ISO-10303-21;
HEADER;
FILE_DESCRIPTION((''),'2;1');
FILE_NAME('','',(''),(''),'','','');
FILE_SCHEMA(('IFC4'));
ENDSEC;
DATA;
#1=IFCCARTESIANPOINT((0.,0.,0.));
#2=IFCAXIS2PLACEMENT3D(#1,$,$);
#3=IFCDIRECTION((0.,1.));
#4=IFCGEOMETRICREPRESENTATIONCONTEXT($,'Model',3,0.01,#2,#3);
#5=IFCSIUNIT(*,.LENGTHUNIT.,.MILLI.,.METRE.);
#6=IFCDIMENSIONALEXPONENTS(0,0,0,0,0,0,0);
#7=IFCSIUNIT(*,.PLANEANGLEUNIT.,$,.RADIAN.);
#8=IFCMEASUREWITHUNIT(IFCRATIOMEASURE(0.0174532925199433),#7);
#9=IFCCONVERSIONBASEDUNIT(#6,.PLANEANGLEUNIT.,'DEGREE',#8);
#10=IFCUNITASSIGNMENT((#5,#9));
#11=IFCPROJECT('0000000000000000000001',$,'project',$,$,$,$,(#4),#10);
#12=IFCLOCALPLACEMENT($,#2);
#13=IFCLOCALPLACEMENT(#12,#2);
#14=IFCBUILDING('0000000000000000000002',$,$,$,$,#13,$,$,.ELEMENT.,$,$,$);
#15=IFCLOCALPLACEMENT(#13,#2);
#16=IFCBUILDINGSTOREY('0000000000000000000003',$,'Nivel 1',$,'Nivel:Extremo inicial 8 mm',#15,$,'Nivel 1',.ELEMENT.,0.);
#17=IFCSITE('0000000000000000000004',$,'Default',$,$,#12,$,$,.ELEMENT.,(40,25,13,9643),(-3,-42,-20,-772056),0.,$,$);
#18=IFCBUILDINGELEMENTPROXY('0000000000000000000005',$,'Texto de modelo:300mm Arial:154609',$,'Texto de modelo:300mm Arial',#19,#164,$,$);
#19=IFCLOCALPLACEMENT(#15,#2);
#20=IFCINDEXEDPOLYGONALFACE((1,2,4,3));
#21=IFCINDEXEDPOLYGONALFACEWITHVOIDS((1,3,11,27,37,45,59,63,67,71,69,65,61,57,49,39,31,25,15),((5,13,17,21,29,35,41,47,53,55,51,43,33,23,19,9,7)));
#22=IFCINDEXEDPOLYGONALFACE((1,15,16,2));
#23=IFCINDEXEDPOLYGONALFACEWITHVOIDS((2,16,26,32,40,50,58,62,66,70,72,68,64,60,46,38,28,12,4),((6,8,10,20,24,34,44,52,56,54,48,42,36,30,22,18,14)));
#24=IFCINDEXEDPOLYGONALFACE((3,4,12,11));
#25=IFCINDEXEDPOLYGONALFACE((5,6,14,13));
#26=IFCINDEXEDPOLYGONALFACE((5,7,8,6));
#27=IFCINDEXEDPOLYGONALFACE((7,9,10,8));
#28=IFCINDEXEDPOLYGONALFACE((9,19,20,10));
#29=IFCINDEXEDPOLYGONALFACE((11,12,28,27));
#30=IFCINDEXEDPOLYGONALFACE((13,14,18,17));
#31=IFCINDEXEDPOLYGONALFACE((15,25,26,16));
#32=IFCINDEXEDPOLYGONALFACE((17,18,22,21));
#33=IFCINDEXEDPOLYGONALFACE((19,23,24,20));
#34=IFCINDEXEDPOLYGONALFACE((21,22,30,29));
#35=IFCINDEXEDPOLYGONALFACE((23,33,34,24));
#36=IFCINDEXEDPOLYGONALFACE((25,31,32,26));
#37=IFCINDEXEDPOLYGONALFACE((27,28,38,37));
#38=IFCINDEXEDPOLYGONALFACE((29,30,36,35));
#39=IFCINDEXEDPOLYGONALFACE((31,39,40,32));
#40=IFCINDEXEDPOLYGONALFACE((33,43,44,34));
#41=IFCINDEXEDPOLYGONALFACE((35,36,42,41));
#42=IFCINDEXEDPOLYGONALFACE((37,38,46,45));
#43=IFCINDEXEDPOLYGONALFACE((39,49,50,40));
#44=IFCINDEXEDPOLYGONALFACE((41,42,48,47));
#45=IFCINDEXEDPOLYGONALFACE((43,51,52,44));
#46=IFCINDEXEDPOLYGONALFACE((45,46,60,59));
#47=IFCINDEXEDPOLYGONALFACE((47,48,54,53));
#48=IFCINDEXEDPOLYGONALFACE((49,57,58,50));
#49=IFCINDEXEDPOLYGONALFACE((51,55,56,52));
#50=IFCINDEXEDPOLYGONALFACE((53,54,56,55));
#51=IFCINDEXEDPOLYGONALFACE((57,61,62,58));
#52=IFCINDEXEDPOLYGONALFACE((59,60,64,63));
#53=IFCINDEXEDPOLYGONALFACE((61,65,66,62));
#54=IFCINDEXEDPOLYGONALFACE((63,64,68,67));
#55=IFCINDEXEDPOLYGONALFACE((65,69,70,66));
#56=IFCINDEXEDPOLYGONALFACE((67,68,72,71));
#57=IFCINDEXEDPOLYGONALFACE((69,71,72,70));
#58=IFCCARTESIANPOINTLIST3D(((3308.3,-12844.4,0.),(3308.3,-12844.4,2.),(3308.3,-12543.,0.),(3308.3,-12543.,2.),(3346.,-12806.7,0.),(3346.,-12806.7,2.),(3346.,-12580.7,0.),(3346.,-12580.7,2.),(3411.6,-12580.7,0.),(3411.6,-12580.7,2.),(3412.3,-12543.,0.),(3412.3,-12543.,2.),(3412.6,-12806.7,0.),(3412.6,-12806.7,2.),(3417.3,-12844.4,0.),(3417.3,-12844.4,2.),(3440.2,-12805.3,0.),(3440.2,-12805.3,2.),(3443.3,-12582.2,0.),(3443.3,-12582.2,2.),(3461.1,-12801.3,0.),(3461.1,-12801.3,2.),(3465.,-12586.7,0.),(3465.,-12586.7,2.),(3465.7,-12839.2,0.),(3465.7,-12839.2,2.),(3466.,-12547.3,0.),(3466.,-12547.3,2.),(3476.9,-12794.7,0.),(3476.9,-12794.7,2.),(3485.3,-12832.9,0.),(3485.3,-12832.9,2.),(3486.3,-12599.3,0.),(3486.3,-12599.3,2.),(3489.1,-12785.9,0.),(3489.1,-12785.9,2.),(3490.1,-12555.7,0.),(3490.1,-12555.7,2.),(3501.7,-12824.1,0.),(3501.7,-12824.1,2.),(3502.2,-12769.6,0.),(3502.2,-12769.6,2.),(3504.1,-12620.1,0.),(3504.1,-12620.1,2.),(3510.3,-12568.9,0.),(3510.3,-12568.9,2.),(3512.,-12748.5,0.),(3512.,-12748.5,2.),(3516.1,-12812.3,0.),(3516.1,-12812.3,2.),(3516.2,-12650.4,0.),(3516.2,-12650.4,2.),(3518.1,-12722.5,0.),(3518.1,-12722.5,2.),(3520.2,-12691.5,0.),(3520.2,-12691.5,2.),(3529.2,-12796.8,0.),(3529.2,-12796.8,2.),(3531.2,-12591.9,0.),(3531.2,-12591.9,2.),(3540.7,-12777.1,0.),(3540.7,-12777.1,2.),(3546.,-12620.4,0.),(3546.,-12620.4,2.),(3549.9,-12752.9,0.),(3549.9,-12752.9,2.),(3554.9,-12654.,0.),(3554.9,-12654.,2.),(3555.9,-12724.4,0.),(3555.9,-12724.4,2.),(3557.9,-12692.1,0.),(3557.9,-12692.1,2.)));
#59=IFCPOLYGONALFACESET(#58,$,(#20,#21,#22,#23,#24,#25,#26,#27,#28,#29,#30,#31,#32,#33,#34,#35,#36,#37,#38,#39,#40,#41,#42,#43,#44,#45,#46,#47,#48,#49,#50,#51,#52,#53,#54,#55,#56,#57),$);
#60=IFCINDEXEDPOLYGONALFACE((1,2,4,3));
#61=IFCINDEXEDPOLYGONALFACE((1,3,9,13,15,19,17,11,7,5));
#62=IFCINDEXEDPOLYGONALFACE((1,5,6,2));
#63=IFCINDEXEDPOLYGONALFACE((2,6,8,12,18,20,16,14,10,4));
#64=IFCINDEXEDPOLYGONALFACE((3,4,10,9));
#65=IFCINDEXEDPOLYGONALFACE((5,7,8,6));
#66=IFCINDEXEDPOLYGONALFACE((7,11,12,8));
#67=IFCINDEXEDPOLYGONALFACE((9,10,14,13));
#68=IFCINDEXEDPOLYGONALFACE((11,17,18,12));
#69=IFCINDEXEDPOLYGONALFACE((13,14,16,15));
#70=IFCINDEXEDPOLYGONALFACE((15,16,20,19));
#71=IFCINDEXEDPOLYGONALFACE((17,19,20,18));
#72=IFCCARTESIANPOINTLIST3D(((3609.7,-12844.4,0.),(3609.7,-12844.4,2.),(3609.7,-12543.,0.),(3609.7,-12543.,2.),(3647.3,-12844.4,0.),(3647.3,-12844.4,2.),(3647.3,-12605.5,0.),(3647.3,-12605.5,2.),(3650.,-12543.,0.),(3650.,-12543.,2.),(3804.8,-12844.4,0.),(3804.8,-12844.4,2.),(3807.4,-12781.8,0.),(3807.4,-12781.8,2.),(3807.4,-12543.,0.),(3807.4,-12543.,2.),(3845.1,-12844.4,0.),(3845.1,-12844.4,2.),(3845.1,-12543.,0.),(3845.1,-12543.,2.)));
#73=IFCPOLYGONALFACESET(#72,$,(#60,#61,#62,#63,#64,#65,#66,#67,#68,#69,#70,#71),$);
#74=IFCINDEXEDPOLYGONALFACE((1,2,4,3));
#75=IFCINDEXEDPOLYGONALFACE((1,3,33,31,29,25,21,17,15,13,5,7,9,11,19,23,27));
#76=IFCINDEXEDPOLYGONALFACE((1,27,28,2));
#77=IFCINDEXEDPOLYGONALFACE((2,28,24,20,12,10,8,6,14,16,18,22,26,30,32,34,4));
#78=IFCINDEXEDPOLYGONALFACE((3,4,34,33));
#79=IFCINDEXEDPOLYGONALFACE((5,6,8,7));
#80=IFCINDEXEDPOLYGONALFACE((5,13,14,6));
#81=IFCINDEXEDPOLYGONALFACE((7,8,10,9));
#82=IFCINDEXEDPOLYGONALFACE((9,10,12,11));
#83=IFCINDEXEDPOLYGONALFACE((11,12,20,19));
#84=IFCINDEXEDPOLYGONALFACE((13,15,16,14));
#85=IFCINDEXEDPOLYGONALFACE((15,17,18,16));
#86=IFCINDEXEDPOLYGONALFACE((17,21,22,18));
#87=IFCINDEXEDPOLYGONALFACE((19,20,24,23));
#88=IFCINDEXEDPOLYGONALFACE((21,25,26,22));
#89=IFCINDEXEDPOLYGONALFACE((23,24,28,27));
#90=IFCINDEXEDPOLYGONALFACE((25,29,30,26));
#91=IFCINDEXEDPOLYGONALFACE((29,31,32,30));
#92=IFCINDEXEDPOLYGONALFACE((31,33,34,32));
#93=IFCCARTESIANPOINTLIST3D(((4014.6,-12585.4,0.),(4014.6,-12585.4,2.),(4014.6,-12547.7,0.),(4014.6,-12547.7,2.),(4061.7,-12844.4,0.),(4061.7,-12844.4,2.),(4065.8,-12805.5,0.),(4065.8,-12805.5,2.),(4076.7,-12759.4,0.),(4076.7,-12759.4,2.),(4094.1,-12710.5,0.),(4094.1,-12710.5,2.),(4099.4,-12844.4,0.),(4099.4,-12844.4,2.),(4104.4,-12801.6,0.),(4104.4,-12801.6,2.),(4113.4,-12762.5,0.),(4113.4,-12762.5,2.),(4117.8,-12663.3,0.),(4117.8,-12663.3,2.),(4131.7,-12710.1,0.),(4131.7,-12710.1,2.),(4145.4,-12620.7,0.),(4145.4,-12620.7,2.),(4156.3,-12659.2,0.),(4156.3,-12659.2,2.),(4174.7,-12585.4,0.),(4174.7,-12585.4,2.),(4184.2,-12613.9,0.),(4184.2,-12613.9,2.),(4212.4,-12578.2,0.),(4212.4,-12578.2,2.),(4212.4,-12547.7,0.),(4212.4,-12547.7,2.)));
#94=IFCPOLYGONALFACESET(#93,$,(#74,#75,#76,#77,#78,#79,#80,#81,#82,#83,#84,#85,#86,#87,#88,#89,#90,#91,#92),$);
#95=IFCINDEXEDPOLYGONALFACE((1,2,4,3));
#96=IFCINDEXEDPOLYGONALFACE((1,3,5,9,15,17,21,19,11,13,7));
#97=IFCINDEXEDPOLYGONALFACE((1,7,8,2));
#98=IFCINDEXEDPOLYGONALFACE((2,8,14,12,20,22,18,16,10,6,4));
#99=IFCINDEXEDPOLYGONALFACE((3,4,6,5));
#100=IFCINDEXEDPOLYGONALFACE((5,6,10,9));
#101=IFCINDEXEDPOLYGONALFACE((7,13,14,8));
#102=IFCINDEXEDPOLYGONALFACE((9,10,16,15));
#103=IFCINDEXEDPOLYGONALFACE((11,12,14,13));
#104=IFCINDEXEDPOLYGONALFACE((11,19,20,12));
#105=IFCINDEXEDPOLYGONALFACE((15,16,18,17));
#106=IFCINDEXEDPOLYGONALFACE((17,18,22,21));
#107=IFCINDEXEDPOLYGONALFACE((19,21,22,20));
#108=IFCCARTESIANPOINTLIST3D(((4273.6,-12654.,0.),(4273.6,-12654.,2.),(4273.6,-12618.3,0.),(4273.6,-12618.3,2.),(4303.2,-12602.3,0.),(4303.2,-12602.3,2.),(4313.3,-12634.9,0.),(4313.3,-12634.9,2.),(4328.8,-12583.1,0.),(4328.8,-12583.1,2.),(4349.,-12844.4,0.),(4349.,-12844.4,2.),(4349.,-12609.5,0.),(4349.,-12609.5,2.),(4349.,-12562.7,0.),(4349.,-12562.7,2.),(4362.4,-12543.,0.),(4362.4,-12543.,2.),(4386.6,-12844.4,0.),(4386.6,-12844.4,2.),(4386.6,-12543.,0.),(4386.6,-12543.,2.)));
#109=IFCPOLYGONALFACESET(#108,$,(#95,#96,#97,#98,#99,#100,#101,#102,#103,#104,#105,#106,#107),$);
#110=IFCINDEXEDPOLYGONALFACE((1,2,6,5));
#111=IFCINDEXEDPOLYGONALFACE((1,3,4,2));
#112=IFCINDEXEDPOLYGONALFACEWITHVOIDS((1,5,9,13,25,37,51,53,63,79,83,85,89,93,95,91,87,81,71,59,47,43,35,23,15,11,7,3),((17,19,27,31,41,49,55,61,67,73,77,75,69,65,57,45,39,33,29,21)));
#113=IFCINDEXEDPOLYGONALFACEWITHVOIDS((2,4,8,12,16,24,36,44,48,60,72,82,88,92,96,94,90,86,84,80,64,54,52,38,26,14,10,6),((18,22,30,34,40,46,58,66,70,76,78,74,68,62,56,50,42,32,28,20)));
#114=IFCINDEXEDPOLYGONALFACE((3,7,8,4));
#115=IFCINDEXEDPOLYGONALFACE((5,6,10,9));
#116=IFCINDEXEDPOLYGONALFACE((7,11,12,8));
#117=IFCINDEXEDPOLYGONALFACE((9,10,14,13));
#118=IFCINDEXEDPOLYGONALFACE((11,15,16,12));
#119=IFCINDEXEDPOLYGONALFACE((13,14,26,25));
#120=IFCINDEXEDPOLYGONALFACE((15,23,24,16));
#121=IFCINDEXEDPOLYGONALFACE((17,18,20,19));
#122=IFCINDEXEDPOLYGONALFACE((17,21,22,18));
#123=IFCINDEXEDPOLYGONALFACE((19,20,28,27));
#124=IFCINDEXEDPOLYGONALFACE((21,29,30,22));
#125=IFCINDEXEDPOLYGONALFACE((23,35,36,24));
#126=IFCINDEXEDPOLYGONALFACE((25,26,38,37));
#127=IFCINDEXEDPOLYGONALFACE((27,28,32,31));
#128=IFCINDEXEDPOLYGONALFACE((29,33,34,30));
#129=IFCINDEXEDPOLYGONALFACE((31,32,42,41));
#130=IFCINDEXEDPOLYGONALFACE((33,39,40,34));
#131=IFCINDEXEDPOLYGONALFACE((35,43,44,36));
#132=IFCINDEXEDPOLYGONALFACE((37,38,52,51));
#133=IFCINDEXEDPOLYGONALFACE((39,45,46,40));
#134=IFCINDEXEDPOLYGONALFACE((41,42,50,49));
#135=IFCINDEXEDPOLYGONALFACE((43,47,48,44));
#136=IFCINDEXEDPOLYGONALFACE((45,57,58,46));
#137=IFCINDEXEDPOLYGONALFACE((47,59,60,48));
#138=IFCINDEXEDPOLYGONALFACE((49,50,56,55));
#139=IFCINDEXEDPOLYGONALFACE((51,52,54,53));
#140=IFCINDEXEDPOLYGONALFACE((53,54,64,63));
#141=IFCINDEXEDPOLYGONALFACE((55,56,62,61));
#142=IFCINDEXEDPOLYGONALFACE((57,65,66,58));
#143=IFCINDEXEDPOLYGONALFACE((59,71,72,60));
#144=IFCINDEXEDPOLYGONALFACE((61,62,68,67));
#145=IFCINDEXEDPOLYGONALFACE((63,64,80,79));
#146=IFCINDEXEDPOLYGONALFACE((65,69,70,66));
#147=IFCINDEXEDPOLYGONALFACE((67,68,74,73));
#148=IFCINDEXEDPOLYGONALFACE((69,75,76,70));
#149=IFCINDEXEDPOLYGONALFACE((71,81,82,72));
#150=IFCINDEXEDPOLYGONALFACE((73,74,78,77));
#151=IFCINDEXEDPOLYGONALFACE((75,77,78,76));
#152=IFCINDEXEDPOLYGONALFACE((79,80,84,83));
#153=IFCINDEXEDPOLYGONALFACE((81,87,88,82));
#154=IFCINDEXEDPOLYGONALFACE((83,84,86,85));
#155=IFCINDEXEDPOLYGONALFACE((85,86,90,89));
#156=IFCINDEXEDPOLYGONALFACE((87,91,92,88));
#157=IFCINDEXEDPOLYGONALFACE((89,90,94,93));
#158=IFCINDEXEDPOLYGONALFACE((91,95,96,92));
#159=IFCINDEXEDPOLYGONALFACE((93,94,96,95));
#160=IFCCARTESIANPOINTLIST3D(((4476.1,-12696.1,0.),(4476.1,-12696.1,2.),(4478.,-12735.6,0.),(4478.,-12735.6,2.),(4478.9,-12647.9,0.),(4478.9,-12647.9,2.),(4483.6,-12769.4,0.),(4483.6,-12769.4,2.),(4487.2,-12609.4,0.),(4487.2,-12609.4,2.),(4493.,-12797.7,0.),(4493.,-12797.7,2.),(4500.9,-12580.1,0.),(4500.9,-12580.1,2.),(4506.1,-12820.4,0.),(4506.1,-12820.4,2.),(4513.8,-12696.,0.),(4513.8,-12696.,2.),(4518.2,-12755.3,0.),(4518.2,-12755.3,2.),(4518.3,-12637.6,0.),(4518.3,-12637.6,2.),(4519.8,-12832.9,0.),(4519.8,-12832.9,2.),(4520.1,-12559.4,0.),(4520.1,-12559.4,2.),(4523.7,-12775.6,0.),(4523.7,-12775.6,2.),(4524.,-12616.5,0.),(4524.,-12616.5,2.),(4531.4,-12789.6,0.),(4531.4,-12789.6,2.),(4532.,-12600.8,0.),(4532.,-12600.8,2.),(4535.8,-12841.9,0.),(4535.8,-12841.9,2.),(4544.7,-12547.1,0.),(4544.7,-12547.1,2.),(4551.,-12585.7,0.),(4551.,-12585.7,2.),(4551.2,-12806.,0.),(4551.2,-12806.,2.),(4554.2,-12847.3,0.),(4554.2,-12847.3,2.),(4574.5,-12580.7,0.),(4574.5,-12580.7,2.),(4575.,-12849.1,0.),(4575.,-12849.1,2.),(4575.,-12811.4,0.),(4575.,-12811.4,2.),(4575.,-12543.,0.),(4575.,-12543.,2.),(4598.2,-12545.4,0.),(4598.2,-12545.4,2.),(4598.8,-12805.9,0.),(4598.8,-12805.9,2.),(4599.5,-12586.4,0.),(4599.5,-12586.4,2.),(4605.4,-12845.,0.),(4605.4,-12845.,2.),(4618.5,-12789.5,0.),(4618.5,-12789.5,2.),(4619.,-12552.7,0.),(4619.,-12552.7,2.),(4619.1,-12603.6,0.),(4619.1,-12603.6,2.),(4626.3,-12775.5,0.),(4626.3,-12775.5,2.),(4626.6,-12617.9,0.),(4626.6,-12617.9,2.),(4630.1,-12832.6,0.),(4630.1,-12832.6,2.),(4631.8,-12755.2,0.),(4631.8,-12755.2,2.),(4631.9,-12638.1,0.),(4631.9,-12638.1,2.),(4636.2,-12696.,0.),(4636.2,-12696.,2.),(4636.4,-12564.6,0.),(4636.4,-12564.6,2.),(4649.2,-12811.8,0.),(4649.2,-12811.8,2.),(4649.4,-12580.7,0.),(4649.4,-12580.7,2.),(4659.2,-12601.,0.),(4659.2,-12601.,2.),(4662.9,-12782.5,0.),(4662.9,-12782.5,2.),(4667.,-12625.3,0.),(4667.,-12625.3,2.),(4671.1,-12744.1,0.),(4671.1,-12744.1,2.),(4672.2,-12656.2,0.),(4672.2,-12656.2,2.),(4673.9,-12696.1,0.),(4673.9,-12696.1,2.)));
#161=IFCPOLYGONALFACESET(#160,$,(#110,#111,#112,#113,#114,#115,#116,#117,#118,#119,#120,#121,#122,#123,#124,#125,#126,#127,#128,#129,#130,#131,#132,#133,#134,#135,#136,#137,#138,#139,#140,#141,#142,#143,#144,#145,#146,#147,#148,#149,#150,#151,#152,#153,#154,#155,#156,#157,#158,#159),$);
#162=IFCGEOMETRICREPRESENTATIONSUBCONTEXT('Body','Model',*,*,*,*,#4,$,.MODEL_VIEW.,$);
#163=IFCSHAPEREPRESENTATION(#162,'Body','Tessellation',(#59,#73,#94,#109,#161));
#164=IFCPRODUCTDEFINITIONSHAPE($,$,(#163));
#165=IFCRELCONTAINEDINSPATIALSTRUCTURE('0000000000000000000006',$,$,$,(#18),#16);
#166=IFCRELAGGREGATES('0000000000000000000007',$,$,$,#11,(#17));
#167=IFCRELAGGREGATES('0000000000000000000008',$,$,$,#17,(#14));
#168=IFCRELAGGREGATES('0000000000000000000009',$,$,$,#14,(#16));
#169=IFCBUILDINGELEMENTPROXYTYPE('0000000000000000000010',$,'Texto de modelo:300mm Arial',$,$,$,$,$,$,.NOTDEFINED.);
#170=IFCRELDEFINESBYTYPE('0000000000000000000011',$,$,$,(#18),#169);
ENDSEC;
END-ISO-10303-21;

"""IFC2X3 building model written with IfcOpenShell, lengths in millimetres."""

from ifc_helpers import new_model, entity, si_unit, converted_unit, direction, frame, origin, place, context, subcontext, project, spatial, polyline, outline, extrude, type_object, element, save


model = new_model("IFC2X3")

# Units and contexts
model_context = context("Model", 3, precision=0.01, world=origin(), true_north=direction((0.0, 1.0)))
body_context = subcontext(model_context, "Body", "Model", "MODEL_VIEW")
ifc_project = project(units=[si_unit("LENGTHUNIT", "METRE", prefix="MILLI"), converted_unit("PLANEANGLEUNIT", "DEGREE", entity("IfcRatioMeasure", 0.0174532925199433), si_unit("PLANEANGLEUNIT", "RADIAN"), dimensions=[0, 0, 0, 0, 0, 0, 0])], contexts=[model_context])

# Site, building, storey
site_placement = place(None, origin())
site = spatial("IfcSite", under=ifc_project, at=site_placement, Name="Default", CompositionType="ELEMENT", RefLatitude=(40, 25, 13, 9643), RefLongitude=(-3, -42, -20, -772056), RefElevation=0.0)
building_placement = place(site_placement, origin())
building = spatial("IfcBuilding", under=site, at=building_placement, CompositionType="ELEMENT")
storey_placement = place(building_placement, origin())
storey = spatial("IfcBuildingStorey", under=building, at=storey_placement, Name="Nivel 1", ObjectType="Nivel:Extremo inicial 8 mm", LongName="Nivel 1", CompositionType="ELEMENT", Elevation=0.0)

# Building element proxy
building_element_proxy_type_1 = type_object("IfcBuildingElementProxyType", Name="Texto de modelo:300mm Arial", PredefinedType="NOTDEFINED")
proxy_1_placement = place(storey_placement, frame((3308.3, -12849.1, 0.0)))
element("IfcBuildingElementProxy", 1, at=proxy_1_placement, inside=storey, type_object=building_element_proxy_type_1, Name="Texto de modelo:300mm Arial:154609", ObjectType="Texto de modelo:300mm Arial", context=body_context, shape_type="SweptSolid", body=[
    extrude(outline(polyline([(-178.4, -141.0), (-69.4, -141.0), (-21.0, -135.8), (-1.4, -129.5), (15.0, -120.7), (29.4, -108.9), (42.6, -93.4), (54.0, -73.7), (63.2, -49.5), (69.2, -21.0), (71.2, 11.3), (68.2, 49.4), (59.3, 83.0), (44.5, 111.5), (23.7, 134.5), (3.4, 147.7), (-20.6, 156.1), (-74.4, 160.4), (-178.4, 160.4), (-178.4, -141.0)]), holes=[polyline([(-140.7, -103.3), (-140.7, 122.7), (-75.1, 122.7), (-43.3, 121.2), (-21.7, 116.7), (-0.4, 104.1), (17.4, 83.3), (29.5, 53.0), (33.5, 11.9), (31.5, -19.1), (25.3, -45.1), (15.5, -66.2), (2.4, -82.5), (-9.8, -91.3), (-25.6, -97.9), (-46.5, -101.9), (-74.1, -103.3), (-140.7, -103.3)])]), frame((178.4, 145.7, 0.0)), (0.0, 0.0, 1.0), 2.0),
    extrude(outline(polyline([(-117.7, -150.7), (-80.1, -150.7), (-80.1, 88.1), (77.4, -150.7), (117.7, -150.7), (117.7, 150.7), (80.1, 150.7), (80.1, -88.1), (-77.4, 150.7), (-117.7, 150.7), (-117.7, -150.7)])), frame((419.1, 155.4, 0.0)), (0.0, 0.0, 1.0), 2.0),
    extrude(outline(polyline([(-101.8, -99.3), (-101.8, -137.0), (96.0, -137.0), (96.0, -106.5), (67.8, -70.9), (39.9, -25.5), (15.2, 25.4), (-3.1, 77.8), (-12.1, 116.9), (-17.1, 159.7), (-54.7, 159.7), (-50.7, 120.8), (-39.8, 74.7), (-22.3, 25.8), (1.3, -21.4), (29.0, -64.0), (58.3, -99.3), (-101.8, -99.3)])), frame((808.2, 164.4, 0.0), z_axis=(0.0, 0.0, -1.0), x_axis=(1.0, 0.0, 0.0)), (0.0, 0.0, -1.0), 2.0),
    extrude(outline(polyline([(-204.4, -52.5), (97.0, -52.5), (97.0, -28.2), (77.2, -14.9), (56.9, 5.3), (37.7, 30.9), (21.6, 60.5), (-14.0, 60.5), (5.0, 20.8), (30.4, -14.9), (-204.4, -14.9), (-204.4, -52.5)])), frame((1025.8, 209.1, 0.0), z_axis=(0.0, 0.0, 1.0), x_axis=(0.0, 1.0, 0.0)), (0.0, 0.0, 1.0), 2.0),
    extrude(outline(polyline([(-5.6, -99.5), (33.9, -99.5), (68.0, -95.5), (96.7, -87.5), (120.0, -75.5), (133.2, -62.4), (142.9, -46.8), (149.1, -28.7), (151.9, -8.0), (149.2, 22.6), (138.0, 47.8), (118.2, 67.9), (89.5, 82.9), (51.6, 93.0), (3.8, 98.0), (-36.2, 98.2), (-67.3, 94.5), (-91.9, 87.9), (-112.6, 79.0), (-129.4, 66.8), (-142.0, 50.0), (-150.3, 29.6), (-153.8, 6.5), (-151.2, -23.9), (-140.1, -49.1), (-120.3, -69.2), (-91.7, -84.4), (-53.6, -94.5), (-5.6, -99.5)]), holes=[polyline([(-3.9, -61.9), (-62.1, -54.6), (-82.9, -47.9), (-98.1, -39.2), (-112.3, -19.5), (-116.2, 4.3), (-109.3, 28.9), (-91.2, 47.7), (-76.5, 54.5), (-56.1, 58.9), (1.9, 60.4), (60.8, 53.2), (80.8, 46.7), (94.5, 38.3), (109.9, 17.8), (114.3, -6.3), (107.7, -29.8), (90.4, -48.7), (76.0, -55.8), (55.5, -60.3), (-3.9, -61.9)])]), frame((1267.5, 152.1, 0.0), z_axis=(0.0, 0.0, 1.0), x_axis=(0.047515, -0.998871, 0.0)), (0.0, 0.0, 1.0), 2.0),
])

save(model, "model.ifc")
